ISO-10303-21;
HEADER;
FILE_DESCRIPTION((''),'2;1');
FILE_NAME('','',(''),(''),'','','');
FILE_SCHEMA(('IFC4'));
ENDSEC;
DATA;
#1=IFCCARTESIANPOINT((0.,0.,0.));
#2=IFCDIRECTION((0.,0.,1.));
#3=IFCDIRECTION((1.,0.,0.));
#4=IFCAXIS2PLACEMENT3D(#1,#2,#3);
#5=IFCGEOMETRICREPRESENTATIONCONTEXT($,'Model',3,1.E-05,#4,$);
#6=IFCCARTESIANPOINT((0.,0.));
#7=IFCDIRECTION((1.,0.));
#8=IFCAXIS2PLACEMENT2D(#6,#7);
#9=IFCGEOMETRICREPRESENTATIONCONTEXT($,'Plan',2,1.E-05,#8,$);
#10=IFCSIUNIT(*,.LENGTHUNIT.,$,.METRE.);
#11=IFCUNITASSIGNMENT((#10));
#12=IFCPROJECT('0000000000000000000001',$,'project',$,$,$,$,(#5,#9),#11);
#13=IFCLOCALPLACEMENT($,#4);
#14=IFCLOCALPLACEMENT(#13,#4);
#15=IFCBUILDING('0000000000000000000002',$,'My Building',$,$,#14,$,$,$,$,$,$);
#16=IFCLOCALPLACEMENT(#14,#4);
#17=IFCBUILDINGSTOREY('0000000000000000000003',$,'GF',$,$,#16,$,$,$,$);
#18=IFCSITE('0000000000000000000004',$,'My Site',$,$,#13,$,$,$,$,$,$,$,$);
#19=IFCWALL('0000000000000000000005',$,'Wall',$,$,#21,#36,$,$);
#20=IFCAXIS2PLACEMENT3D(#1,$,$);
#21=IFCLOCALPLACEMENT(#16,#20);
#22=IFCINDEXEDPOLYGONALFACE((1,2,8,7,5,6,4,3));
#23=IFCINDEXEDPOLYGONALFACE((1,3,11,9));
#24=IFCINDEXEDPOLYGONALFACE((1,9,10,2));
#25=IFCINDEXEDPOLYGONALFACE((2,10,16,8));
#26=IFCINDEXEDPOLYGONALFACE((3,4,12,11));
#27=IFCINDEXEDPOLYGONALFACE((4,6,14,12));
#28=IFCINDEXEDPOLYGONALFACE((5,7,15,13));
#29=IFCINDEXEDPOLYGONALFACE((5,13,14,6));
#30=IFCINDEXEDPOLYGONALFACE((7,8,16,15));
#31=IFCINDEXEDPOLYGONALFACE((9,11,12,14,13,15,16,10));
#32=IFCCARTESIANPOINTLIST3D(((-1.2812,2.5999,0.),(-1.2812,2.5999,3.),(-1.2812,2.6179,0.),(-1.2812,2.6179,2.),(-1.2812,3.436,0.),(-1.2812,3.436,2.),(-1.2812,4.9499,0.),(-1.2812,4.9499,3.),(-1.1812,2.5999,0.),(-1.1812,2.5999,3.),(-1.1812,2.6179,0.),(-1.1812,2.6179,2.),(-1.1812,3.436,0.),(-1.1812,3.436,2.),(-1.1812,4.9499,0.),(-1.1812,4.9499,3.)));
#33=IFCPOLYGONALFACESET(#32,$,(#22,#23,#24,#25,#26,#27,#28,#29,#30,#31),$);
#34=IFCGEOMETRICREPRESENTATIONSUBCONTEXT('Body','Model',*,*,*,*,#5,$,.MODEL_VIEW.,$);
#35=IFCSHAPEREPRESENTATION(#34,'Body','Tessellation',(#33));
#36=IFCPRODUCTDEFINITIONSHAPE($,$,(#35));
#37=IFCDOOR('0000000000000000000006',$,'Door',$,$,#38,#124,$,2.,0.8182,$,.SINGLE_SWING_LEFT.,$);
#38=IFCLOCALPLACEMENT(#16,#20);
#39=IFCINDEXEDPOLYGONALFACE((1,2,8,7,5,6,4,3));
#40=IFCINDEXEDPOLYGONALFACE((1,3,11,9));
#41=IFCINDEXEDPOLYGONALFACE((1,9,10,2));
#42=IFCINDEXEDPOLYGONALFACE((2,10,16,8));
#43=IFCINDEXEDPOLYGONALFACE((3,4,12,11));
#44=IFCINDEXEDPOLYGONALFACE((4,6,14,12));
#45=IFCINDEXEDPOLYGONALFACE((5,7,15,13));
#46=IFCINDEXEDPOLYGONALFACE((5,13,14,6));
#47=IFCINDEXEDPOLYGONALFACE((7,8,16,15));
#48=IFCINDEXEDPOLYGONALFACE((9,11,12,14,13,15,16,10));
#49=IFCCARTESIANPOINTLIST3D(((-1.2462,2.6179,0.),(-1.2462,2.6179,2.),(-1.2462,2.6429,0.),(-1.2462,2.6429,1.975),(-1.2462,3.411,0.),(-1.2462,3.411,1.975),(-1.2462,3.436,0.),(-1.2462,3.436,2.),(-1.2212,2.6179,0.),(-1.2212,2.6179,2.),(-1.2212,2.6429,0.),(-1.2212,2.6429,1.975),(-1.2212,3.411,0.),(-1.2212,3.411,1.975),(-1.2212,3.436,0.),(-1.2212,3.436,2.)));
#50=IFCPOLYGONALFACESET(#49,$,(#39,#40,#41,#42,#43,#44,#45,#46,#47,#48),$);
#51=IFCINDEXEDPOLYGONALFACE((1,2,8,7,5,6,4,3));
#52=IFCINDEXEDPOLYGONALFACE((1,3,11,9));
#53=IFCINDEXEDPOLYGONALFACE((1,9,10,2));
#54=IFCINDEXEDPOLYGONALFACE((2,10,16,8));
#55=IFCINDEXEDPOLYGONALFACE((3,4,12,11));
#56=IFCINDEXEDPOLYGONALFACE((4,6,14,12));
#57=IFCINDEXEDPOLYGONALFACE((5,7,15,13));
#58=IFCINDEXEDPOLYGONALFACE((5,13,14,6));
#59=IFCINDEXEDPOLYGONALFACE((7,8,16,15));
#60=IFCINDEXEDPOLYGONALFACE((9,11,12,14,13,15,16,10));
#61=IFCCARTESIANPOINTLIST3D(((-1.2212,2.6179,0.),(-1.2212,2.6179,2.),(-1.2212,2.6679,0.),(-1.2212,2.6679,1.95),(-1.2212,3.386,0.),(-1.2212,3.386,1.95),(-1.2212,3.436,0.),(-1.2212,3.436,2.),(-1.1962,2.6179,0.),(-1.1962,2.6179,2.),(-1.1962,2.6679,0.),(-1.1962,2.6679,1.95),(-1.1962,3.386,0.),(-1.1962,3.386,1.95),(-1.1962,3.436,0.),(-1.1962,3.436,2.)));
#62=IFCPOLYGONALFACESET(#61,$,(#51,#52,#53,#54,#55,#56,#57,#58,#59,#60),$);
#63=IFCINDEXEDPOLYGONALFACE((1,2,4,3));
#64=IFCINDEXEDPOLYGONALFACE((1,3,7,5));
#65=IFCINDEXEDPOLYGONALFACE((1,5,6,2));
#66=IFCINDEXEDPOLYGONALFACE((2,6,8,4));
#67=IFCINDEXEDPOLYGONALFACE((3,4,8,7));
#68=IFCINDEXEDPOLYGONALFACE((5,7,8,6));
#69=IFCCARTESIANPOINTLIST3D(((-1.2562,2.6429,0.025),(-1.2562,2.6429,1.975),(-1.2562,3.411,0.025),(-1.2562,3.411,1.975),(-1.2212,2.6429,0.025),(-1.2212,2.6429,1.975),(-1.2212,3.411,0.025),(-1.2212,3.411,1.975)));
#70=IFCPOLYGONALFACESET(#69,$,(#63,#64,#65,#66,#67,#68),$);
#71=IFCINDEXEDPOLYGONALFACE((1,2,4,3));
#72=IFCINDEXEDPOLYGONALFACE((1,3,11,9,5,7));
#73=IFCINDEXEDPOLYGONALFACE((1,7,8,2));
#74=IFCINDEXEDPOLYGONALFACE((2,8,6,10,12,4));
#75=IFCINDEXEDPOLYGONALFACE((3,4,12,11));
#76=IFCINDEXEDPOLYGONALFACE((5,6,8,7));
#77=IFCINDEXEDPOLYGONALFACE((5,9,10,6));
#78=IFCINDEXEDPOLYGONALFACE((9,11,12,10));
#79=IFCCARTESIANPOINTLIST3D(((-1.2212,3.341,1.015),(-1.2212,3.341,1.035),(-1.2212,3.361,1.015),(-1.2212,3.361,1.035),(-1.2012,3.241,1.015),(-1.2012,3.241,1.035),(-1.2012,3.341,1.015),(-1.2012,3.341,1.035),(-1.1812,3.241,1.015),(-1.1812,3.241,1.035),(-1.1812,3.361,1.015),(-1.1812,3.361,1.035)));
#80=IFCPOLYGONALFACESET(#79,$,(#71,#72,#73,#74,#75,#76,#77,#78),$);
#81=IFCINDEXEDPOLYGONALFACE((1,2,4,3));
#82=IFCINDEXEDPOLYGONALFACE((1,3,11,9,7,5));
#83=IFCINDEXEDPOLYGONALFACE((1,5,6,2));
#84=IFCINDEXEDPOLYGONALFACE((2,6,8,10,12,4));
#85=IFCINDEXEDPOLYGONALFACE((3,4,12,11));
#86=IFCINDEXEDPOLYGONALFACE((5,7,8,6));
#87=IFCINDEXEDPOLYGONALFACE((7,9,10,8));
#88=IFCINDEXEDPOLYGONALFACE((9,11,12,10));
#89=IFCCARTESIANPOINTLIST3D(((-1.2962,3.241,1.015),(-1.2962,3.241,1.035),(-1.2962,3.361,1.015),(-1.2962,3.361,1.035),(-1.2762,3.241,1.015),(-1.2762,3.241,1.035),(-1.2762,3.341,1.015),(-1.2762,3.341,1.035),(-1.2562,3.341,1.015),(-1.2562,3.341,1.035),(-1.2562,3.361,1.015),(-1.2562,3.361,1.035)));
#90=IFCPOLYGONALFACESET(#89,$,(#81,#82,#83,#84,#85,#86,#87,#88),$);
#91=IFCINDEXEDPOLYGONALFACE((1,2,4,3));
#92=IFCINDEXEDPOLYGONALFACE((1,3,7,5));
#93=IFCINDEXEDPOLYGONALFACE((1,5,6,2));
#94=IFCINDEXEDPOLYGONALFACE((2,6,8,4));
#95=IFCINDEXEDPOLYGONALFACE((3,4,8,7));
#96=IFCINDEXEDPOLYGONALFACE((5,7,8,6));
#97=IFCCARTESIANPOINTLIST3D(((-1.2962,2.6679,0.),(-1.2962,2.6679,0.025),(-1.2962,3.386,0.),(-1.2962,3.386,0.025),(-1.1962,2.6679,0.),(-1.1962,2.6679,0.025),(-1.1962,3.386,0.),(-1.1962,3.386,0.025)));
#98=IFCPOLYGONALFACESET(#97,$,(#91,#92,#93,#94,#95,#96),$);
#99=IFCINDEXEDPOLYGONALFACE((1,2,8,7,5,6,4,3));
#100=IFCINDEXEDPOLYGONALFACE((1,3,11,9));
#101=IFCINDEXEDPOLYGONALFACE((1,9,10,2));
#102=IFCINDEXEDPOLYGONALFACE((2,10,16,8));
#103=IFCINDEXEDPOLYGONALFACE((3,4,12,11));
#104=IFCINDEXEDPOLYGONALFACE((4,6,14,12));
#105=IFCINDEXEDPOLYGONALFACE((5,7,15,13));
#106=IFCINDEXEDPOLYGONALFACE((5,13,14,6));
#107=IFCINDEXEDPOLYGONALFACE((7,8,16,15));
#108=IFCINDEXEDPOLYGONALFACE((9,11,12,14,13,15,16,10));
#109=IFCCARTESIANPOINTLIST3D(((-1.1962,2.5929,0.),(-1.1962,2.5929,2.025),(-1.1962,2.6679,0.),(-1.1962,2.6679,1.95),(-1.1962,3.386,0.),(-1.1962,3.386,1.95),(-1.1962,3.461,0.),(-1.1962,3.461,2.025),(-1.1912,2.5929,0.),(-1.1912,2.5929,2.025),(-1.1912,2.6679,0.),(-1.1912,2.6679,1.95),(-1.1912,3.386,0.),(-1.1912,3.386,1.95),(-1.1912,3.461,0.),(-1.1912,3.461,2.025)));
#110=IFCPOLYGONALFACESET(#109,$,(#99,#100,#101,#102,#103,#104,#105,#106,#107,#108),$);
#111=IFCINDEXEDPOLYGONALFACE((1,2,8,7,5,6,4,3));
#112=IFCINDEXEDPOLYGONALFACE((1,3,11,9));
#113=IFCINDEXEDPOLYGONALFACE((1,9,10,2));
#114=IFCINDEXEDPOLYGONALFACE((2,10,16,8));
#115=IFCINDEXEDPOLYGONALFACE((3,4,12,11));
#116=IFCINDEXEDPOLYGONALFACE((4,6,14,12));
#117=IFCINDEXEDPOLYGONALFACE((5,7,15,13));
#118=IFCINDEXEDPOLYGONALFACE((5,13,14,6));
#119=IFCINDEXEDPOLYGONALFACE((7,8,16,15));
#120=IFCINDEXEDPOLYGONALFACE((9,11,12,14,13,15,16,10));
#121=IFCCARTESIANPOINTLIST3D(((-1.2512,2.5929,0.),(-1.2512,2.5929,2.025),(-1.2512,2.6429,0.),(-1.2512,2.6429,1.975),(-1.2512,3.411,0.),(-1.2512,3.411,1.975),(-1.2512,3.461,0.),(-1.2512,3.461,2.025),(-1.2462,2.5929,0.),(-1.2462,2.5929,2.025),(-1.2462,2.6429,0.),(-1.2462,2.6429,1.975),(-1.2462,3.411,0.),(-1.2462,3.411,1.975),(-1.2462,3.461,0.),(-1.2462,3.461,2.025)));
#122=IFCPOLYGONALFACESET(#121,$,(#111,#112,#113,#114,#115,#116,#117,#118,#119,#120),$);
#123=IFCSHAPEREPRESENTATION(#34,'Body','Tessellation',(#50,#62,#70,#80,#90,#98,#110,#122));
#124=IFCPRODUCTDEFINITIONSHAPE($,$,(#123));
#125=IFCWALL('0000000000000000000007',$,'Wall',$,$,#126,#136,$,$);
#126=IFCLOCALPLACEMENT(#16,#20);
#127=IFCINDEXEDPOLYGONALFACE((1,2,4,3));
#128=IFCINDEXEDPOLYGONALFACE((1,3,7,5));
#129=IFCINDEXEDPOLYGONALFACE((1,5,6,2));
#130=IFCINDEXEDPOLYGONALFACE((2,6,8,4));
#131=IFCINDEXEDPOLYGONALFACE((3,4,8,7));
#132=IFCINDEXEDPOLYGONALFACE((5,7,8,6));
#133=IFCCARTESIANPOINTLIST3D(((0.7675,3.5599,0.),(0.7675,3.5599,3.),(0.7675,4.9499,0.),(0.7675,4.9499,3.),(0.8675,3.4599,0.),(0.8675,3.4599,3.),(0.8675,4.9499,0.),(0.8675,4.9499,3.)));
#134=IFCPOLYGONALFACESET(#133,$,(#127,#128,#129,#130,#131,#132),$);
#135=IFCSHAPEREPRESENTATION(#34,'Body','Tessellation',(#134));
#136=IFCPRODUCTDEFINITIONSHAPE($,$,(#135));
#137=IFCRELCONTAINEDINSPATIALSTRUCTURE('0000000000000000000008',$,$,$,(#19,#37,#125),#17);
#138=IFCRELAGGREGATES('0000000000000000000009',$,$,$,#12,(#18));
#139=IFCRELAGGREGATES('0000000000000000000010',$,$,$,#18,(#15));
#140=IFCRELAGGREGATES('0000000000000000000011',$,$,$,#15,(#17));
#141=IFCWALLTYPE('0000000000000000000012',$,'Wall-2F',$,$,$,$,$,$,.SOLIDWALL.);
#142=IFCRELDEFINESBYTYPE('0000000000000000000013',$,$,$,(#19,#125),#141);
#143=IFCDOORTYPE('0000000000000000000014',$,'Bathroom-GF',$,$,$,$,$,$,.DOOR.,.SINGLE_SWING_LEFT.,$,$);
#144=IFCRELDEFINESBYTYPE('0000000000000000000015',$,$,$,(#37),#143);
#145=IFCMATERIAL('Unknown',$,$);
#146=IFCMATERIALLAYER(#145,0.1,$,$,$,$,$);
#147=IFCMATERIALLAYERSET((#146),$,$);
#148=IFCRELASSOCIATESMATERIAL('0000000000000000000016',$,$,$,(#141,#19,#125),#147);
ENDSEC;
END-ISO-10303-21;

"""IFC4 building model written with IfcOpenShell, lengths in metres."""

from ifc_helpers import new_model, entity, si_unit, frame, origin_with_axes, origin_2d_with_axis, place, context, subcontext, project, spatial, line, indexed_curve, outline, extrude, shape, source, transform, mapped, material, layer, layer_set, layer_usage, type_object, type_shapes, element, fill, save


model = new_model("IFC4")

# Units and contexts
model_context = context("Model", 3, precision=1e-05, world=origin_with_axes())
plan_context = context("Plan", 2, precision=1e-05, world=origin_2d_with_axis())
body_context_1 = subcontext(model_context, "Body", "Model", "MODEL_VIEW")
body_context_2 = subcontext(plan_context, "Body", "Plan", "PLAN_VIEW")
ifc_project = project(units=[si_unit("LENGTHUNIT", "METRE")], contexts=[model_context, plan_context])

# Site, building, storey
site_placement = place(None, origin_with_axes())
site = spatial("IfcSite", under=ifc_project, at=site_placement, Name="My Site")
building_placement = place(site_placement, origin_with_axes())
building = spatial("IfcBuilding", under=site, at=building_placement, Name="My Building")
storey_placement = place(building_placement, origin_with_axes())
storey = spatial("IfcBuildingStorey", under=building, at=storey_placement, Name="GF")

# Shared definitions
ifc_material_1 = material(Name="Unknown")

# Shared definitions
ifc_layer_1 = layer(ifc_material_1, 0.1)
ifc_layer_set_1 = layer_set([ifc_layer_1])
wall_type = type_object("IfcWallType", Name="Wall-2F", PredefinedType="SOLIDWALL", material=ifc_layer_set_1)

# Wall, opening, door
ifc_layer_usage_1 = layer_usage(ifc_layer_set_1, "AXIS2", "POSITIVE", 0.0)
wall_1_placement = place(storey_placement, frame((-1.1812, 2.5999, 0.0), z_axis=(0.0, 0.0, 1.0), x_axis=(0.0, 1.0, 0.0)))
wall_1 = element("IfcWall", 1, at=wall_1_placement, inside=storey, type_object=wall_type, material=ifc_layer_usage_1, Name="Wall", context=body_context_1, shape_type="SweptSolid", body=[
    extrude(outline(indexed_curve([(0.0, 0.0), (0.0, 0.1), (2.35, 0.1), (2.35, 0.0)], segments=[line(1, 2, 3, 4, 1)])), origin_with_axes(), (0.0, 0.0, 1.0), 3.0),
])
shared_shape_1 = source(origin_with_axes(), body_context_1, "Body", "SweptSolid", [
    extrude(outline(indexed_curve([(0.0, 0.0), (0.8182, 0.0), (0.8182, 2.0), (0.0, 2.0)], segments=[line(1, 2, 3, 4, 1)])), frame((0.0, -0.6, 0.0), z_axis=(0.0, -1.0, 0.0), x_axis=(1.0, 0.0, 0.0)), (0.0, 0.0, -1.0), 1.2),
])
opening_1_placement = place(wall_1_placement, frame((0.0179, 0.015, 0.0), z_axis=(0.0, 0.0, 1.0), x_axis=(1.0, 0.0, 0.0)))
opening_1 = element("IfcOpeningElement", 2, at=opening_1_placement, cuts=wall_1, PredefinedType="OPENING", context=body_context_1, shape_type="MappedRepresentation", body=[
    mapped(shared_shape_1, transform((0.0, 0.0, 0.0), x_axis=(1.0, 0.0, 0.0), y_axis=(0.0, 1.0, 0.0), z_axis=(0.0, 0.0, 1.0), scale=1.0)),
])
door_type_1 = type_object("IfcDoorType", Name="Bathroom-GF", OperationType="SINGLE_SWING_LEFT", PredefinedType="DOOR")
shared_shape_2 = source(origin_with_axes(), body_context_1, "Body", "SweptSolid", [
    extrude(outline(indexed_curve([(0.0, 0.0), (0.0, 2.0), (0.8182, 2.0), (0.8182, 0.0), (0.7932, 0.0), (0.7932, 1.975), (0.025, 1.975), (0.025, 0.0)], segments=[line(1, 2, 3, 4, 5, 6, 7, 8, 1)])), frame((0.0, 0.025, 0.0), z_axis=(0.0, -1.0, 0.0), x_axis=(1.0, 0.0, 0.0)), (0.0, 0.0, -1.0), 0.025),
    extrude(outline(indexed_curve([(0.0, 0.0), (0.0, 2.0), (0.8182, 2.0), (0.8182, 0.0), (0.7682, 0.0), (0.7682, 1.95), (0.05, 1.95), (0.05, 0.0)], segments=[line(1, 2, 3, 4, 5, 6, 7, 8, 1)])), frame((0.0, 0.0, 0.0), z_axis=(0.0, -1.0, 0.0), x_axis=(1.0, 0.0, 0.0)), (0.0, 0.0, -1.0), 0.025),
    extrude(outline(indexed_curve([(0.0, 0.0), (0.7682, 0.0), (0.7682, 0.035), (0.0, 0.035)], segments=[line(1, 2, 3, 4, 1)])), frame((0.025, 0.025, 0.025), z_axis=(0.0, 0.0, 1.0), x_axis=(1.0, 0.0, 0.0)), (0.0, 0.0, 1.0), 1.95),
    extrude(outline(indexed_curve([(0.0, 0.0), (0.0, -0.04), (-0.12, -0.04), (-0.12, -0.02), (-0.02, -0.02), (-0.02, 0.0)], segments=[line(1, 2, 3, 4, 5, 6, 1)])), frame((0.7432, 0.025, 1.015), z_axis=(0.0, 0.0, 1.0), x_axis=(1.0, 0.0, 0.0)), (0.0, 0.0, 1.0), 0.02),
    extrude(outline(indexed_curve([(0.0, 0.0), (0.0, 0.04), (-0.12, 0.04), (-0.12, 0.02), (-0.02, 0.02), (-0.02, 0.0)], segments=[line(1, 2, 3, 4, 5, 6, 1)])), frame((0.7432, 0.06, 1.015), z_axis=(0.0, 0.0, 1.0), x_axis=(1.0, 0.0, 0.0)), (0.0, 0.0, 1.0), 0.02),
    extrude(outline(indexed_curve([(0.0, 0.0), (0.7182, 0.0), (0.7182, 0.1), (0.0, 0.1)], segments=[line(1, 2, 3, 4, 1)])), frame((0.05, 0.0, 0.0), z_axis=(0.0, 0.0, 1.0), x_axis=(1.0, 0.0, 0.0)), (0.0, 0.0, 1.0), 0.025),
    extrude(outline(indexed_curve([(0.0, 0.0), (0.0, 2.025), (0.8682, 2.025), (0.8682, 0.0), (0.7932, 0.0), (0.7932, 1.95), (0.075, 1.95), (0.075, 0.0)], segments=[line(1, 2, 3, 4, 5, 6, 7, 8, 1)])), frame((-0.025, -0.005, 0.0), z_axis=(0.0, -1.0, 0.0), x_axis=(1.0, 0.0, 0.0)), (0.0, 0.0, -1.0), 0.005),
    extrude(outline(indexed_curve([(0.0, 0.0), (0.0, 2.025), (0.8682, 2.025), (0.8682, 0.0), (0.8182, 0.0), (0.8182, 1.975), (0.05, 1.975), (0.05, 0.0)], segments=[line(1, 2, 3, 4, 5, 6, 7, 8, 1)])), frame((-0.025, 0.05, 0.0), z_axis=(0.0, -1.0, 0.0), x_axis=(1.0, 0.0, 0.0)), (0.0, 0.0, -1.0), 0.005),
])
shared_shape_3 = source(origin_with_axes(), body_context_2, "Body", "Curve2D", [
    entity("IfcIndexedPolyCurve", entity("IfcCartesianPointList2D", [[0.0, 0.0], [0.0, 0.05], [0.025, 0.05], [0.025, 0.025], [0.05, 0.025], [0.05, 0.0]]), [entity("IfcLineIndex", [1, 2, 3, 4, 5, 6, 1])]),
    entity("IfcIndexedPolyCurve", entity("IfcCartesianPointList2D", [[0.8182, 0.0], [0.8182, 0.05], [0.7932, 0.05], [0.7932, 0.025], [0.7682, 0.025], [0.7682, 0.0]]), [entity("IfcLineIndex", [1, 2, 3, 4, 5, 6, 1])]),
    entity("IfcTrimmedCurve", entity("IfcEllipse", entity("IfcAxis2Placement2D", entity("IfcCartesianPoint", [0.06, 0.05]), entity("IfcDirection", [1.0, 0.0])), 0.7332, 0.7682), [entity("IfcCartesianPoint", [0.7932, 0.05])], [entity("IfcCartesianPoint", [0.06, 0.8182])], True, "CARTESIAN"),
    entity("IfcIndexedPolyCurve", entity("IfcCartesianPointList2D", [[0.025, 0.05], [0.06, 0.05], [0.06, 0.8182], [0.025, 0.8182]]), [entity("IfcLineIndex", [1, 2, 3, 4, 1])]),
])
type_shapes(door_type_1, [shared_shape_2, shared_shape_3])
door_1_placement = place(opening_1_placement, frame((0.0, 0.0, 0.0), z_axis=(0.0, 0.0, 1.0), x_axis=(1.0, 0.0, 0.0)))
door_1 = element("IfcDoor", 3, at=door_1_placement, inside=storey, type_object=door_type_1, Name="Door", OperationType="SINGLE_SWING_LEFT", OverallHeight=2.0, OverallWidth=0.8182, shapes=[
    shape(body_context_1, "Body", "MappedRepresentation", [mapped(shared_shape_2, transform((0.0, 0.0, 0.0), x_axis=(1.0, 0.0, 0.0), y_axis=(0.0, 1.0, 0.0), z_axis=(0.0, 0.0, 1.0), scale=1.0))]),
    shape(body_context_2, "Body", "MappedRepresentation", [mapped(shared_shape_3, transform((0.0, 0.0, 0.0), x_axis=(1.0, 0.0, 0.0), y_axis=(0.0, 1.0, 0.0), z_axis=(0.0, 0.0, 1.0), scale=1.0))]),
])
fill(opening_1, door_1)

# Wall
ifc_layer_usage_2 = layer_usage(ifc_layer_set_1, "AXIS2", "POSITIVE", 0.0)
wall_2_placement = place(storey_placement, frame((0.7675, 5.0499, 0.0), z_axis=(0.0, 0.0, 1.0), x_axis=(0.0, -1.0, 0.0)))
element("IfcWall", 4, at=wall_2_placement, inside=storey, type_object=wall_type, material=ifc_layer_usage_2, Name="Wall", context=body_context_1, shape_type="SweptSolid", body=[
    extrude(outline(indexed_curve([(0.1, 0.0), (0.1, 0.1), (1.59, 0.1), (1.49, 0.0)], segments=[line(1, 2, 3, 4, 1)])), origin_with_axes(), (0.0, 0.0, 1.0), 3.0),
])

save(model, "model.ifc")
